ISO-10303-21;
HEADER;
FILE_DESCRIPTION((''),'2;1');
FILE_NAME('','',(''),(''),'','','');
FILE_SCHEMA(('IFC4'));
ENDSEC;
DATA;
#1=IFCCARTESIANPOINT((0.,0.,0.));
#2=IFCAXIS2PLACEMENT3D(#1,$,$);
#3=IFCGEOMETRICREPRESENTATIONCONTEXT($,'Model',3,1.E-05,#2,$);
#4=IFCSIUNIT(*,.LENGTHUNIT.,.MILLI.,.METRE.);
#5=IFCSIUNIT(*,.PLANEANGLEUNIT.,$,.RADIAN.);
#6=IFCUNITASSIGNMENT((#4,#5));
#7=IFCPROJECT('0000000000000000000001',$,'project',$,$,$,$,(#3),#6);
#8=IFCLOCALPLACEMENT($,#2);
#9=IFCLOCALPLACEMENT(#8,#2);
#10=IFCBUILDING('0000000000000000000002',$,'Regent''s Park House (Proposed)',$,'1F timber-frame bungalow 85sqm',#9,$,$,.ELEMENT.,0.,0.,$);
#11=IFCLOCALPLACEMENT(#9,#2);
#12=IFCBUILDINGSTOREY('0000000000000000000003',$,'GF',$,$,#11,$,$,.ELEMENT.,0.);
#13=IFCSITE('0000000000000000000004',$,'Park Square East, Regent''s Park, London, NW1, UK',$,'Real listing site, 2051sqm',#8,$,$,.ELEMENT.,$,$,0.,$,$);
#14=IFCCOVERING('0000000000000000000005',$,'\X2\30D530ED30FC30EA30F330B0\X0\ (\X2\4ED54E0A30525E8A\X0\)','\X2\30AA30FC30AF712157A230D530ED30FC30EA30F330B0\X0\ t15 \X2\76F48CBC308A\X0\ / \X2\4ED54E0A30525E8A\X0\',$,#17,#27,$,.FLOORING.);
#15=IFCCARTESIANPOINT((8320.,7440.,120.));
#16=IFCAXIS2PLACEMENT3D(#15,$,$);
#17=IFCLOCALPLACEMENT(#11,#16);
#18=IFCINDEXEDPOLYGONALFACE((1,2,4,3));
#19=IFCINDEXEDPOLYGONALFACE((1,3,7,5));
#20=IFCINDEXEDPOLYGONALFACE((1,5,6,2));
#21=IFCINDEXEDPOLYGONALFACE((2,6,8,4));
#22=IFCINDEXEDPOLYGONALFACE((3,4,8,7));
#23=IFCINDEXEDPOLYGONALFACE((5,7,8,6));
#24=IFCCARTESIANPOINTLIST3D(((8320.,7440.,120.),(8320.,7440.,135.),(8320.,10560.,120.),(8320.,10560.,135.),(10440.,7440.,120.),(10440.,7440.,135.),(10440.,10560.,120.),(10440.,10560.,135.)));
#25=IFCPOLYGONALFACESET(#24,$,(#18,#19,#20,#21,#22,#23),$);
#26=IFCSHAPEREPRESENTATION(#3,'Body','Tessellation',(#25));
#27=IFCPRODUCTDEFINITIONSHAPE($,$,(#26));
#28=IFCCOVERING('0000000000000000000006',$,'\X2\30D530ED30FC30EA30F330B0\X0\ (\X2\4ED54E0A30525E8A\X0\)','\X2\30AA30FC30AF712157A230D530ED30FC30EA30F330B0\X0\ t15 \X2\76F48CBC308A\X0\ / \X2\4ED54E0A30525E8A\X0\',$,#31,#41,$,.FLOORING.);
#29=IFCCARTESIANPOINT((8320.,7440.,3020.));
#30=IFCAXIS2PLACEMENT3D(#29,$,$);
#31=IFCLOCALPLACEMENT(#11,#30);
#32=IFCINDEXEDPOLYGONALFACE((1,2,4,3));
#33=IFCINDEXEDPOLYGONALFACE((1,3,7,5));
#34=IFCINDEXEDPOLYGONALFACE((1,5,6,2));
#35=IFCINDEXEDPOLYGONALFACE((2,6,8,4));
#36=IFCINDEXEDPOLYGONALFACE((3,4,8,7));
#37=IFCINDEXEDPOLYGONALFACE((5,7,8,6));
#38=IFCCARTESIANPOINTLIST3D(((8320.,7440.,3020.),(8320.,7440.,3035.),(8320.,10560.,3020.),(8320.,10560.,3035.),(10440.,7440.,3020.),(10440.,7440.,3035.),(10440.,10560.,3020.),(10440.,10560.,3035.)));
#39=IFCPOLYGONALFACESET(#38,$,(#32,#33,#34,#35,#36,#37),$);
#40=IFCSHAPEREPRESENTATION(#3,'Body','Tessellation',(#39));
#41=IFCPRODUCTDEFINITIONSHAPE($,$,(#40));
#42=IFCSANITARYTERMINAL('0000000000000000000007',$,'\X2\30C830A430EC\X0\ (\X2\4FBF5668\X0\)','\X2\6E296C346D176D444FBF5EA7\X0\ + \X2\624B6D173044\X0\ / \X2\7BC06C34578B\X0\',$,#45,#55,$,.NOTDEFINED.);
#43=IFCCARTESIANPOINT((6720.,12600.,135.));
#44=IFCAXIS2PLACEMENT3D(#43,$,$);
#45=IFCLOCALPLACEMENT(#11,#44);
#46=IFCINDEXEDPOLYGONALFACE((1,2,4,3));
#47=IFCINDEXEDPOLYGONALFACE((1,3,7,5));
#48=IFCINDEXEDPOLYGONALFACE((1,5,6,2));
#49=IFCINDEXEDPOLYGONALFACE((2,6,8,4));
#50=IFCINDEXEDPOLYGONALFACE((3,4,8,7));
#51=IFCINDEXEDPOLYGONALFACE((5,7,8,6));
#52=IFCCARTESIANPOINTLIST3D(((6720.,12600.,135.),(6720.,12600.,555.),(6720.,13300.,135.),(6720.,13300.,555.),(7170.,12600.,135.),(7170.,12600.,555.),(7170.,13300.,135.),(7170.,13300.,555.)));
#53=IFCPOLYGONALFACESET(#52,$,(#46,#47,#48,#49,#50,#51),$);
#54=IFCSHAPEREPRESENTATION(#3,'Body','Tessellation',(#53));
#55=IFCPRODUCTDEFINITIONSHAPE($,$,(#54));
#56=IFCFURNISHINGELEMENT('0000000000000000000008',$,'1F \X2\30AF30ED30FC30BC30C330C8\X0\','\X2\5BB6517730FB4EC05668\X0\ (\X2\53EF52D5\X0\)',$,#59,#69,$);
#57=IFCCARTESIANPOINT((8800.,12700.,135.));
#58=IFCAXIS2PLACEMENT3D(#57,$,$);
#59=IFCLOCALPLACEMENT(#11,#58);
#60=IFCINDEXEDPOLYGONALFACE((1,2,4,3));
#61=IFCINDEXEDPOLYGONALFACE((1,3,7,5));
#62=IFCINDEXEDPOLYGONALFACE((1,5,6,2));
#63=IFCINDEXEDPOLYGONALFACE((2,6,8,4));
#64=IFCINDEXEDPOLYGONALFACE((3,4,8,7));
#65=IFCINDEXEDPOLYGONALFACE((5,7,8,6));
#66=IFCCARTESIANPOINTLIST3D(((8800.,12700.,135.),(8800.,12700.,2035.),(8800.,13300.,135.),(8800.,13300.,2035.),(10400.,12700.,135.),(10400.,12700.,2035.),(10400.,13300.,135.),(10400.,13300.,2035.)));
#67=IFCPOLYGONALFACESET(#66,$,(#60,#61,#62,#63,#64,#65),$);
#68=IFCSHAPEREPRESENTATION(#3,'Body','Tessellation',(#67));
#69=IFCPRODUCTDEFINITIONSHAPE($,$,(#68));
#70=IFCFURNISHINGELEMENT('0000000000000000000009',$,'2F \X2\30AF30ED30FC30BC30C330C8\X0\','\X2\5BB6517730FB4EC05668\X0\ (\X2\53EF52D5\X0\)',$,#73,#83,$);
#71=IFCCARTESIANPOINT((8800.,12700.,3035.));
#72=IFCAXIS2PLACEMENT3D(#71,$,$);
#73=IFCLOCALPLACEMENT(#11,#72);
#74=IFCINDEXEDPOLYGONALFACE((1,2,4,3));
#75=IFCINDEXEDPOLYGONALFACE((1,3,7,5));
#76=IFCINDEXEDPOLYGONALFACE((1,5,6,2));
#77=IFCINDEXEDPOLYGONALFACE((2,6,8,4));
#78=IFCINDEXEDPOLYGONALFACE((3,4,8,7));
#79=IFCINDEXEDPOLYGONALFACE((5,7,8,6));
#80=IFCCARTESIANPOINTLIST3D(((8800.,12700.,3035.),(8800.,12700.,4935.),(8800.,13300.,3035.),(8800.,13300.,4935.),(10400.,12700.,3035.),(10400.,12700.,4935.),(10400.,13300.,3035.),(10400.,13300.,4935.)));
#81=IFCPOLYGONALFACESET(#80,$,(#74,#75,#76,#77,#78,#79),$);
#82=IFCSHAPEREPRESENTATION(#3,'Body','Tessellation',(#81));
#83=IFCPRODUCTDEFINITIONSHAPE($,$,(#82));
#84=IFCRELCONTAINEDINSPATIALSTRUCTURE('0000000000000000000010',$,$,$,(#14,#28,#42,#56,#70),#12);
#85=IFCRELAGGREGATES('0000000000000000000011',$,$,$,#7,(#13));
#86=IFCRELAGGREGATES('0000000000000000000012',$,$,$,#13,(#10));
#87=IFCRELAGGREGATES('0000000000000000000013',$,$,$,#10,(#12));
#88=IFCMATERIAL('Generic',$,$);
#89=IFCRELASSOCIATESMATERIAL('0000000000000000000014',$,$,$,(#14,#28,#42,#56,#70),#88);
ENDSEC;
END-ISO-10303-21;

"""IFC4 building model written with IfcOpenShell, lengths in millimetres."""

from ifc_helpers import new_model, si_unit, frame, frame_2d, origin, place, context, project, spatial, rectangle, extrude, material, element, save


model = new_model("IFC4")

# Units and contexts
model_context = context("Model", 3, precision=1e-05, world=origin())
ifc_project = project(units=[si_unit("LENGTHUNIT", "METRE", prefix="MILLI"), si_unit("PLANEANGLEUNIT", "RADIAN")], contexts=[model_context])

# Site, building, storey
site_placement = place(None, origin())
site = spatial("IfcSite", under=ifc_project, at=site_placement, Name="Park Square East, Regent's Park, London, NW1, UK", ObjectType="Real listing site, 2051sqm", CompositionType="ELEMENT", RefElevation=0.0)
building_placement = place(site_placement, origin())
building = spatial("IfcBuilding", under=site, at=building_placement, Name="Regent's Park House (Proposed)", ObjectType="1F timber-frame bungalow 85sqm", CompositionType="ELEMENT", ElevationOfRefHeight=0.0, ElevationOfTerrain=0.0)
storey_placement = place(building_placement, origin())
storey = spatial("IfcBuildingStorey", under=building, at=storey_placement, Name="GF", CompositionType="ELEMENT", Elevation=0.0)

# Shared definitions
ifc_material_1 = material(Name="Generic")

# Coverings
covering_1_placement = place(storey_placement, frame((8320.0, 7440.0, 120.0)))
element("IfcCovering", 1, at=covering_1_placement, inside=storey, material=ifc_material_1, Name="フローリング (仕上げ床)", Description="オーク無垢フローリング t15 直貼り / 仕上げ床", PredefinedType="FLOORING", context=model_context, shape_type="SweptSolid", body=[
    extrude(rectangle(XDim=2120.0, YDim=3120.0, at=frame_2d((1060.0, 1560.0))), frame((8320.0, 7440.0, 120.0)), (0.0, 0.0, 1.0), 15.0),
])
covering_2_placement = place(storey_placement, frame((8320.0, 7440.0, 3020.0)))
element("IfcCovering", 2, at=covering_2_placement, inside=storey, material=ifc_material_1, Name="フローリング (仕上げ床)", Description="オーク無垢フローリング t15 直貼り / 仕上げ床", PredefinedType="FLOORING", context=model_context, shape_type="SweptSolid", body=[
    extrude(rectangle(XDim=2120.0, YDim=3120.0, at=frame_2d((1060.0, 1560.0))), frame((8320.0, 7440.0, 3020.0)), (0.0, 0.0, 1.0), 15.0),
])

# Sanitary terminal
sanitary_terminal_placement = place(storey_placement, frame((6720.0, 12600.0, 135.0)))
element("IfcSanitaryTerminal", 3, at=sanitary_terminal_placement, inside=storey, material=ifc_material_1, Name="トイレ (便器)", Description="温水洗浄便座 + 手洗い / 節水型", PredefinedType="NOTDEFINED", context=model_context, shape_type="SweptSolid", body=[
    extrude(rectangle(XDim=450.0, YDim=700.0, at=frame_2d((225.0, 350.0))), frame((6720.0, 12600.0, 135.0)), (0.0, 0.0, 1.0), 420.0),
])

# Furnishing elements
furnishing_1_placement = place(storey_placement, frame((8800.0, 12700.0, 135.0)))
element("IfcFurnishingElement", 4, at=furnishing_1_placement, inside=storey, material=ifc_material_1, Name="1F クローゼット", Description="家具・什器 (可動)", context=model_context, shape_type="SweptSolid", body=[
    extrude(rectangle(XDim=1600.0, YDim=600.0, at=frame_2d((800.0, 300.0))), frame((8800.0, 12700.0, 135.0)), (0.0, 0.0, 1.0), 1900.0),
])
furnishing_2_placement = place(storey_placement, frame((8800.0, 12700.0, 3035.0)))
element("IfcFurnishingElement", 5, at=furnishing_2_placement, inside=storey, material=ifc_material_1, Name="2F クローゼット", Description="家具・什器 (可動)", context=model_context, shape_type="SweptSolid", body=[
    extrude(rectangle(XDim=1600.0, YDim=600.0, at=frame_2d((800.0, 300.0))), frame((8800.0, 12700.0, 3035.0)), (0.0, 0.0, 1.0), 1900.0),
])

save(model, "model.ifc")
